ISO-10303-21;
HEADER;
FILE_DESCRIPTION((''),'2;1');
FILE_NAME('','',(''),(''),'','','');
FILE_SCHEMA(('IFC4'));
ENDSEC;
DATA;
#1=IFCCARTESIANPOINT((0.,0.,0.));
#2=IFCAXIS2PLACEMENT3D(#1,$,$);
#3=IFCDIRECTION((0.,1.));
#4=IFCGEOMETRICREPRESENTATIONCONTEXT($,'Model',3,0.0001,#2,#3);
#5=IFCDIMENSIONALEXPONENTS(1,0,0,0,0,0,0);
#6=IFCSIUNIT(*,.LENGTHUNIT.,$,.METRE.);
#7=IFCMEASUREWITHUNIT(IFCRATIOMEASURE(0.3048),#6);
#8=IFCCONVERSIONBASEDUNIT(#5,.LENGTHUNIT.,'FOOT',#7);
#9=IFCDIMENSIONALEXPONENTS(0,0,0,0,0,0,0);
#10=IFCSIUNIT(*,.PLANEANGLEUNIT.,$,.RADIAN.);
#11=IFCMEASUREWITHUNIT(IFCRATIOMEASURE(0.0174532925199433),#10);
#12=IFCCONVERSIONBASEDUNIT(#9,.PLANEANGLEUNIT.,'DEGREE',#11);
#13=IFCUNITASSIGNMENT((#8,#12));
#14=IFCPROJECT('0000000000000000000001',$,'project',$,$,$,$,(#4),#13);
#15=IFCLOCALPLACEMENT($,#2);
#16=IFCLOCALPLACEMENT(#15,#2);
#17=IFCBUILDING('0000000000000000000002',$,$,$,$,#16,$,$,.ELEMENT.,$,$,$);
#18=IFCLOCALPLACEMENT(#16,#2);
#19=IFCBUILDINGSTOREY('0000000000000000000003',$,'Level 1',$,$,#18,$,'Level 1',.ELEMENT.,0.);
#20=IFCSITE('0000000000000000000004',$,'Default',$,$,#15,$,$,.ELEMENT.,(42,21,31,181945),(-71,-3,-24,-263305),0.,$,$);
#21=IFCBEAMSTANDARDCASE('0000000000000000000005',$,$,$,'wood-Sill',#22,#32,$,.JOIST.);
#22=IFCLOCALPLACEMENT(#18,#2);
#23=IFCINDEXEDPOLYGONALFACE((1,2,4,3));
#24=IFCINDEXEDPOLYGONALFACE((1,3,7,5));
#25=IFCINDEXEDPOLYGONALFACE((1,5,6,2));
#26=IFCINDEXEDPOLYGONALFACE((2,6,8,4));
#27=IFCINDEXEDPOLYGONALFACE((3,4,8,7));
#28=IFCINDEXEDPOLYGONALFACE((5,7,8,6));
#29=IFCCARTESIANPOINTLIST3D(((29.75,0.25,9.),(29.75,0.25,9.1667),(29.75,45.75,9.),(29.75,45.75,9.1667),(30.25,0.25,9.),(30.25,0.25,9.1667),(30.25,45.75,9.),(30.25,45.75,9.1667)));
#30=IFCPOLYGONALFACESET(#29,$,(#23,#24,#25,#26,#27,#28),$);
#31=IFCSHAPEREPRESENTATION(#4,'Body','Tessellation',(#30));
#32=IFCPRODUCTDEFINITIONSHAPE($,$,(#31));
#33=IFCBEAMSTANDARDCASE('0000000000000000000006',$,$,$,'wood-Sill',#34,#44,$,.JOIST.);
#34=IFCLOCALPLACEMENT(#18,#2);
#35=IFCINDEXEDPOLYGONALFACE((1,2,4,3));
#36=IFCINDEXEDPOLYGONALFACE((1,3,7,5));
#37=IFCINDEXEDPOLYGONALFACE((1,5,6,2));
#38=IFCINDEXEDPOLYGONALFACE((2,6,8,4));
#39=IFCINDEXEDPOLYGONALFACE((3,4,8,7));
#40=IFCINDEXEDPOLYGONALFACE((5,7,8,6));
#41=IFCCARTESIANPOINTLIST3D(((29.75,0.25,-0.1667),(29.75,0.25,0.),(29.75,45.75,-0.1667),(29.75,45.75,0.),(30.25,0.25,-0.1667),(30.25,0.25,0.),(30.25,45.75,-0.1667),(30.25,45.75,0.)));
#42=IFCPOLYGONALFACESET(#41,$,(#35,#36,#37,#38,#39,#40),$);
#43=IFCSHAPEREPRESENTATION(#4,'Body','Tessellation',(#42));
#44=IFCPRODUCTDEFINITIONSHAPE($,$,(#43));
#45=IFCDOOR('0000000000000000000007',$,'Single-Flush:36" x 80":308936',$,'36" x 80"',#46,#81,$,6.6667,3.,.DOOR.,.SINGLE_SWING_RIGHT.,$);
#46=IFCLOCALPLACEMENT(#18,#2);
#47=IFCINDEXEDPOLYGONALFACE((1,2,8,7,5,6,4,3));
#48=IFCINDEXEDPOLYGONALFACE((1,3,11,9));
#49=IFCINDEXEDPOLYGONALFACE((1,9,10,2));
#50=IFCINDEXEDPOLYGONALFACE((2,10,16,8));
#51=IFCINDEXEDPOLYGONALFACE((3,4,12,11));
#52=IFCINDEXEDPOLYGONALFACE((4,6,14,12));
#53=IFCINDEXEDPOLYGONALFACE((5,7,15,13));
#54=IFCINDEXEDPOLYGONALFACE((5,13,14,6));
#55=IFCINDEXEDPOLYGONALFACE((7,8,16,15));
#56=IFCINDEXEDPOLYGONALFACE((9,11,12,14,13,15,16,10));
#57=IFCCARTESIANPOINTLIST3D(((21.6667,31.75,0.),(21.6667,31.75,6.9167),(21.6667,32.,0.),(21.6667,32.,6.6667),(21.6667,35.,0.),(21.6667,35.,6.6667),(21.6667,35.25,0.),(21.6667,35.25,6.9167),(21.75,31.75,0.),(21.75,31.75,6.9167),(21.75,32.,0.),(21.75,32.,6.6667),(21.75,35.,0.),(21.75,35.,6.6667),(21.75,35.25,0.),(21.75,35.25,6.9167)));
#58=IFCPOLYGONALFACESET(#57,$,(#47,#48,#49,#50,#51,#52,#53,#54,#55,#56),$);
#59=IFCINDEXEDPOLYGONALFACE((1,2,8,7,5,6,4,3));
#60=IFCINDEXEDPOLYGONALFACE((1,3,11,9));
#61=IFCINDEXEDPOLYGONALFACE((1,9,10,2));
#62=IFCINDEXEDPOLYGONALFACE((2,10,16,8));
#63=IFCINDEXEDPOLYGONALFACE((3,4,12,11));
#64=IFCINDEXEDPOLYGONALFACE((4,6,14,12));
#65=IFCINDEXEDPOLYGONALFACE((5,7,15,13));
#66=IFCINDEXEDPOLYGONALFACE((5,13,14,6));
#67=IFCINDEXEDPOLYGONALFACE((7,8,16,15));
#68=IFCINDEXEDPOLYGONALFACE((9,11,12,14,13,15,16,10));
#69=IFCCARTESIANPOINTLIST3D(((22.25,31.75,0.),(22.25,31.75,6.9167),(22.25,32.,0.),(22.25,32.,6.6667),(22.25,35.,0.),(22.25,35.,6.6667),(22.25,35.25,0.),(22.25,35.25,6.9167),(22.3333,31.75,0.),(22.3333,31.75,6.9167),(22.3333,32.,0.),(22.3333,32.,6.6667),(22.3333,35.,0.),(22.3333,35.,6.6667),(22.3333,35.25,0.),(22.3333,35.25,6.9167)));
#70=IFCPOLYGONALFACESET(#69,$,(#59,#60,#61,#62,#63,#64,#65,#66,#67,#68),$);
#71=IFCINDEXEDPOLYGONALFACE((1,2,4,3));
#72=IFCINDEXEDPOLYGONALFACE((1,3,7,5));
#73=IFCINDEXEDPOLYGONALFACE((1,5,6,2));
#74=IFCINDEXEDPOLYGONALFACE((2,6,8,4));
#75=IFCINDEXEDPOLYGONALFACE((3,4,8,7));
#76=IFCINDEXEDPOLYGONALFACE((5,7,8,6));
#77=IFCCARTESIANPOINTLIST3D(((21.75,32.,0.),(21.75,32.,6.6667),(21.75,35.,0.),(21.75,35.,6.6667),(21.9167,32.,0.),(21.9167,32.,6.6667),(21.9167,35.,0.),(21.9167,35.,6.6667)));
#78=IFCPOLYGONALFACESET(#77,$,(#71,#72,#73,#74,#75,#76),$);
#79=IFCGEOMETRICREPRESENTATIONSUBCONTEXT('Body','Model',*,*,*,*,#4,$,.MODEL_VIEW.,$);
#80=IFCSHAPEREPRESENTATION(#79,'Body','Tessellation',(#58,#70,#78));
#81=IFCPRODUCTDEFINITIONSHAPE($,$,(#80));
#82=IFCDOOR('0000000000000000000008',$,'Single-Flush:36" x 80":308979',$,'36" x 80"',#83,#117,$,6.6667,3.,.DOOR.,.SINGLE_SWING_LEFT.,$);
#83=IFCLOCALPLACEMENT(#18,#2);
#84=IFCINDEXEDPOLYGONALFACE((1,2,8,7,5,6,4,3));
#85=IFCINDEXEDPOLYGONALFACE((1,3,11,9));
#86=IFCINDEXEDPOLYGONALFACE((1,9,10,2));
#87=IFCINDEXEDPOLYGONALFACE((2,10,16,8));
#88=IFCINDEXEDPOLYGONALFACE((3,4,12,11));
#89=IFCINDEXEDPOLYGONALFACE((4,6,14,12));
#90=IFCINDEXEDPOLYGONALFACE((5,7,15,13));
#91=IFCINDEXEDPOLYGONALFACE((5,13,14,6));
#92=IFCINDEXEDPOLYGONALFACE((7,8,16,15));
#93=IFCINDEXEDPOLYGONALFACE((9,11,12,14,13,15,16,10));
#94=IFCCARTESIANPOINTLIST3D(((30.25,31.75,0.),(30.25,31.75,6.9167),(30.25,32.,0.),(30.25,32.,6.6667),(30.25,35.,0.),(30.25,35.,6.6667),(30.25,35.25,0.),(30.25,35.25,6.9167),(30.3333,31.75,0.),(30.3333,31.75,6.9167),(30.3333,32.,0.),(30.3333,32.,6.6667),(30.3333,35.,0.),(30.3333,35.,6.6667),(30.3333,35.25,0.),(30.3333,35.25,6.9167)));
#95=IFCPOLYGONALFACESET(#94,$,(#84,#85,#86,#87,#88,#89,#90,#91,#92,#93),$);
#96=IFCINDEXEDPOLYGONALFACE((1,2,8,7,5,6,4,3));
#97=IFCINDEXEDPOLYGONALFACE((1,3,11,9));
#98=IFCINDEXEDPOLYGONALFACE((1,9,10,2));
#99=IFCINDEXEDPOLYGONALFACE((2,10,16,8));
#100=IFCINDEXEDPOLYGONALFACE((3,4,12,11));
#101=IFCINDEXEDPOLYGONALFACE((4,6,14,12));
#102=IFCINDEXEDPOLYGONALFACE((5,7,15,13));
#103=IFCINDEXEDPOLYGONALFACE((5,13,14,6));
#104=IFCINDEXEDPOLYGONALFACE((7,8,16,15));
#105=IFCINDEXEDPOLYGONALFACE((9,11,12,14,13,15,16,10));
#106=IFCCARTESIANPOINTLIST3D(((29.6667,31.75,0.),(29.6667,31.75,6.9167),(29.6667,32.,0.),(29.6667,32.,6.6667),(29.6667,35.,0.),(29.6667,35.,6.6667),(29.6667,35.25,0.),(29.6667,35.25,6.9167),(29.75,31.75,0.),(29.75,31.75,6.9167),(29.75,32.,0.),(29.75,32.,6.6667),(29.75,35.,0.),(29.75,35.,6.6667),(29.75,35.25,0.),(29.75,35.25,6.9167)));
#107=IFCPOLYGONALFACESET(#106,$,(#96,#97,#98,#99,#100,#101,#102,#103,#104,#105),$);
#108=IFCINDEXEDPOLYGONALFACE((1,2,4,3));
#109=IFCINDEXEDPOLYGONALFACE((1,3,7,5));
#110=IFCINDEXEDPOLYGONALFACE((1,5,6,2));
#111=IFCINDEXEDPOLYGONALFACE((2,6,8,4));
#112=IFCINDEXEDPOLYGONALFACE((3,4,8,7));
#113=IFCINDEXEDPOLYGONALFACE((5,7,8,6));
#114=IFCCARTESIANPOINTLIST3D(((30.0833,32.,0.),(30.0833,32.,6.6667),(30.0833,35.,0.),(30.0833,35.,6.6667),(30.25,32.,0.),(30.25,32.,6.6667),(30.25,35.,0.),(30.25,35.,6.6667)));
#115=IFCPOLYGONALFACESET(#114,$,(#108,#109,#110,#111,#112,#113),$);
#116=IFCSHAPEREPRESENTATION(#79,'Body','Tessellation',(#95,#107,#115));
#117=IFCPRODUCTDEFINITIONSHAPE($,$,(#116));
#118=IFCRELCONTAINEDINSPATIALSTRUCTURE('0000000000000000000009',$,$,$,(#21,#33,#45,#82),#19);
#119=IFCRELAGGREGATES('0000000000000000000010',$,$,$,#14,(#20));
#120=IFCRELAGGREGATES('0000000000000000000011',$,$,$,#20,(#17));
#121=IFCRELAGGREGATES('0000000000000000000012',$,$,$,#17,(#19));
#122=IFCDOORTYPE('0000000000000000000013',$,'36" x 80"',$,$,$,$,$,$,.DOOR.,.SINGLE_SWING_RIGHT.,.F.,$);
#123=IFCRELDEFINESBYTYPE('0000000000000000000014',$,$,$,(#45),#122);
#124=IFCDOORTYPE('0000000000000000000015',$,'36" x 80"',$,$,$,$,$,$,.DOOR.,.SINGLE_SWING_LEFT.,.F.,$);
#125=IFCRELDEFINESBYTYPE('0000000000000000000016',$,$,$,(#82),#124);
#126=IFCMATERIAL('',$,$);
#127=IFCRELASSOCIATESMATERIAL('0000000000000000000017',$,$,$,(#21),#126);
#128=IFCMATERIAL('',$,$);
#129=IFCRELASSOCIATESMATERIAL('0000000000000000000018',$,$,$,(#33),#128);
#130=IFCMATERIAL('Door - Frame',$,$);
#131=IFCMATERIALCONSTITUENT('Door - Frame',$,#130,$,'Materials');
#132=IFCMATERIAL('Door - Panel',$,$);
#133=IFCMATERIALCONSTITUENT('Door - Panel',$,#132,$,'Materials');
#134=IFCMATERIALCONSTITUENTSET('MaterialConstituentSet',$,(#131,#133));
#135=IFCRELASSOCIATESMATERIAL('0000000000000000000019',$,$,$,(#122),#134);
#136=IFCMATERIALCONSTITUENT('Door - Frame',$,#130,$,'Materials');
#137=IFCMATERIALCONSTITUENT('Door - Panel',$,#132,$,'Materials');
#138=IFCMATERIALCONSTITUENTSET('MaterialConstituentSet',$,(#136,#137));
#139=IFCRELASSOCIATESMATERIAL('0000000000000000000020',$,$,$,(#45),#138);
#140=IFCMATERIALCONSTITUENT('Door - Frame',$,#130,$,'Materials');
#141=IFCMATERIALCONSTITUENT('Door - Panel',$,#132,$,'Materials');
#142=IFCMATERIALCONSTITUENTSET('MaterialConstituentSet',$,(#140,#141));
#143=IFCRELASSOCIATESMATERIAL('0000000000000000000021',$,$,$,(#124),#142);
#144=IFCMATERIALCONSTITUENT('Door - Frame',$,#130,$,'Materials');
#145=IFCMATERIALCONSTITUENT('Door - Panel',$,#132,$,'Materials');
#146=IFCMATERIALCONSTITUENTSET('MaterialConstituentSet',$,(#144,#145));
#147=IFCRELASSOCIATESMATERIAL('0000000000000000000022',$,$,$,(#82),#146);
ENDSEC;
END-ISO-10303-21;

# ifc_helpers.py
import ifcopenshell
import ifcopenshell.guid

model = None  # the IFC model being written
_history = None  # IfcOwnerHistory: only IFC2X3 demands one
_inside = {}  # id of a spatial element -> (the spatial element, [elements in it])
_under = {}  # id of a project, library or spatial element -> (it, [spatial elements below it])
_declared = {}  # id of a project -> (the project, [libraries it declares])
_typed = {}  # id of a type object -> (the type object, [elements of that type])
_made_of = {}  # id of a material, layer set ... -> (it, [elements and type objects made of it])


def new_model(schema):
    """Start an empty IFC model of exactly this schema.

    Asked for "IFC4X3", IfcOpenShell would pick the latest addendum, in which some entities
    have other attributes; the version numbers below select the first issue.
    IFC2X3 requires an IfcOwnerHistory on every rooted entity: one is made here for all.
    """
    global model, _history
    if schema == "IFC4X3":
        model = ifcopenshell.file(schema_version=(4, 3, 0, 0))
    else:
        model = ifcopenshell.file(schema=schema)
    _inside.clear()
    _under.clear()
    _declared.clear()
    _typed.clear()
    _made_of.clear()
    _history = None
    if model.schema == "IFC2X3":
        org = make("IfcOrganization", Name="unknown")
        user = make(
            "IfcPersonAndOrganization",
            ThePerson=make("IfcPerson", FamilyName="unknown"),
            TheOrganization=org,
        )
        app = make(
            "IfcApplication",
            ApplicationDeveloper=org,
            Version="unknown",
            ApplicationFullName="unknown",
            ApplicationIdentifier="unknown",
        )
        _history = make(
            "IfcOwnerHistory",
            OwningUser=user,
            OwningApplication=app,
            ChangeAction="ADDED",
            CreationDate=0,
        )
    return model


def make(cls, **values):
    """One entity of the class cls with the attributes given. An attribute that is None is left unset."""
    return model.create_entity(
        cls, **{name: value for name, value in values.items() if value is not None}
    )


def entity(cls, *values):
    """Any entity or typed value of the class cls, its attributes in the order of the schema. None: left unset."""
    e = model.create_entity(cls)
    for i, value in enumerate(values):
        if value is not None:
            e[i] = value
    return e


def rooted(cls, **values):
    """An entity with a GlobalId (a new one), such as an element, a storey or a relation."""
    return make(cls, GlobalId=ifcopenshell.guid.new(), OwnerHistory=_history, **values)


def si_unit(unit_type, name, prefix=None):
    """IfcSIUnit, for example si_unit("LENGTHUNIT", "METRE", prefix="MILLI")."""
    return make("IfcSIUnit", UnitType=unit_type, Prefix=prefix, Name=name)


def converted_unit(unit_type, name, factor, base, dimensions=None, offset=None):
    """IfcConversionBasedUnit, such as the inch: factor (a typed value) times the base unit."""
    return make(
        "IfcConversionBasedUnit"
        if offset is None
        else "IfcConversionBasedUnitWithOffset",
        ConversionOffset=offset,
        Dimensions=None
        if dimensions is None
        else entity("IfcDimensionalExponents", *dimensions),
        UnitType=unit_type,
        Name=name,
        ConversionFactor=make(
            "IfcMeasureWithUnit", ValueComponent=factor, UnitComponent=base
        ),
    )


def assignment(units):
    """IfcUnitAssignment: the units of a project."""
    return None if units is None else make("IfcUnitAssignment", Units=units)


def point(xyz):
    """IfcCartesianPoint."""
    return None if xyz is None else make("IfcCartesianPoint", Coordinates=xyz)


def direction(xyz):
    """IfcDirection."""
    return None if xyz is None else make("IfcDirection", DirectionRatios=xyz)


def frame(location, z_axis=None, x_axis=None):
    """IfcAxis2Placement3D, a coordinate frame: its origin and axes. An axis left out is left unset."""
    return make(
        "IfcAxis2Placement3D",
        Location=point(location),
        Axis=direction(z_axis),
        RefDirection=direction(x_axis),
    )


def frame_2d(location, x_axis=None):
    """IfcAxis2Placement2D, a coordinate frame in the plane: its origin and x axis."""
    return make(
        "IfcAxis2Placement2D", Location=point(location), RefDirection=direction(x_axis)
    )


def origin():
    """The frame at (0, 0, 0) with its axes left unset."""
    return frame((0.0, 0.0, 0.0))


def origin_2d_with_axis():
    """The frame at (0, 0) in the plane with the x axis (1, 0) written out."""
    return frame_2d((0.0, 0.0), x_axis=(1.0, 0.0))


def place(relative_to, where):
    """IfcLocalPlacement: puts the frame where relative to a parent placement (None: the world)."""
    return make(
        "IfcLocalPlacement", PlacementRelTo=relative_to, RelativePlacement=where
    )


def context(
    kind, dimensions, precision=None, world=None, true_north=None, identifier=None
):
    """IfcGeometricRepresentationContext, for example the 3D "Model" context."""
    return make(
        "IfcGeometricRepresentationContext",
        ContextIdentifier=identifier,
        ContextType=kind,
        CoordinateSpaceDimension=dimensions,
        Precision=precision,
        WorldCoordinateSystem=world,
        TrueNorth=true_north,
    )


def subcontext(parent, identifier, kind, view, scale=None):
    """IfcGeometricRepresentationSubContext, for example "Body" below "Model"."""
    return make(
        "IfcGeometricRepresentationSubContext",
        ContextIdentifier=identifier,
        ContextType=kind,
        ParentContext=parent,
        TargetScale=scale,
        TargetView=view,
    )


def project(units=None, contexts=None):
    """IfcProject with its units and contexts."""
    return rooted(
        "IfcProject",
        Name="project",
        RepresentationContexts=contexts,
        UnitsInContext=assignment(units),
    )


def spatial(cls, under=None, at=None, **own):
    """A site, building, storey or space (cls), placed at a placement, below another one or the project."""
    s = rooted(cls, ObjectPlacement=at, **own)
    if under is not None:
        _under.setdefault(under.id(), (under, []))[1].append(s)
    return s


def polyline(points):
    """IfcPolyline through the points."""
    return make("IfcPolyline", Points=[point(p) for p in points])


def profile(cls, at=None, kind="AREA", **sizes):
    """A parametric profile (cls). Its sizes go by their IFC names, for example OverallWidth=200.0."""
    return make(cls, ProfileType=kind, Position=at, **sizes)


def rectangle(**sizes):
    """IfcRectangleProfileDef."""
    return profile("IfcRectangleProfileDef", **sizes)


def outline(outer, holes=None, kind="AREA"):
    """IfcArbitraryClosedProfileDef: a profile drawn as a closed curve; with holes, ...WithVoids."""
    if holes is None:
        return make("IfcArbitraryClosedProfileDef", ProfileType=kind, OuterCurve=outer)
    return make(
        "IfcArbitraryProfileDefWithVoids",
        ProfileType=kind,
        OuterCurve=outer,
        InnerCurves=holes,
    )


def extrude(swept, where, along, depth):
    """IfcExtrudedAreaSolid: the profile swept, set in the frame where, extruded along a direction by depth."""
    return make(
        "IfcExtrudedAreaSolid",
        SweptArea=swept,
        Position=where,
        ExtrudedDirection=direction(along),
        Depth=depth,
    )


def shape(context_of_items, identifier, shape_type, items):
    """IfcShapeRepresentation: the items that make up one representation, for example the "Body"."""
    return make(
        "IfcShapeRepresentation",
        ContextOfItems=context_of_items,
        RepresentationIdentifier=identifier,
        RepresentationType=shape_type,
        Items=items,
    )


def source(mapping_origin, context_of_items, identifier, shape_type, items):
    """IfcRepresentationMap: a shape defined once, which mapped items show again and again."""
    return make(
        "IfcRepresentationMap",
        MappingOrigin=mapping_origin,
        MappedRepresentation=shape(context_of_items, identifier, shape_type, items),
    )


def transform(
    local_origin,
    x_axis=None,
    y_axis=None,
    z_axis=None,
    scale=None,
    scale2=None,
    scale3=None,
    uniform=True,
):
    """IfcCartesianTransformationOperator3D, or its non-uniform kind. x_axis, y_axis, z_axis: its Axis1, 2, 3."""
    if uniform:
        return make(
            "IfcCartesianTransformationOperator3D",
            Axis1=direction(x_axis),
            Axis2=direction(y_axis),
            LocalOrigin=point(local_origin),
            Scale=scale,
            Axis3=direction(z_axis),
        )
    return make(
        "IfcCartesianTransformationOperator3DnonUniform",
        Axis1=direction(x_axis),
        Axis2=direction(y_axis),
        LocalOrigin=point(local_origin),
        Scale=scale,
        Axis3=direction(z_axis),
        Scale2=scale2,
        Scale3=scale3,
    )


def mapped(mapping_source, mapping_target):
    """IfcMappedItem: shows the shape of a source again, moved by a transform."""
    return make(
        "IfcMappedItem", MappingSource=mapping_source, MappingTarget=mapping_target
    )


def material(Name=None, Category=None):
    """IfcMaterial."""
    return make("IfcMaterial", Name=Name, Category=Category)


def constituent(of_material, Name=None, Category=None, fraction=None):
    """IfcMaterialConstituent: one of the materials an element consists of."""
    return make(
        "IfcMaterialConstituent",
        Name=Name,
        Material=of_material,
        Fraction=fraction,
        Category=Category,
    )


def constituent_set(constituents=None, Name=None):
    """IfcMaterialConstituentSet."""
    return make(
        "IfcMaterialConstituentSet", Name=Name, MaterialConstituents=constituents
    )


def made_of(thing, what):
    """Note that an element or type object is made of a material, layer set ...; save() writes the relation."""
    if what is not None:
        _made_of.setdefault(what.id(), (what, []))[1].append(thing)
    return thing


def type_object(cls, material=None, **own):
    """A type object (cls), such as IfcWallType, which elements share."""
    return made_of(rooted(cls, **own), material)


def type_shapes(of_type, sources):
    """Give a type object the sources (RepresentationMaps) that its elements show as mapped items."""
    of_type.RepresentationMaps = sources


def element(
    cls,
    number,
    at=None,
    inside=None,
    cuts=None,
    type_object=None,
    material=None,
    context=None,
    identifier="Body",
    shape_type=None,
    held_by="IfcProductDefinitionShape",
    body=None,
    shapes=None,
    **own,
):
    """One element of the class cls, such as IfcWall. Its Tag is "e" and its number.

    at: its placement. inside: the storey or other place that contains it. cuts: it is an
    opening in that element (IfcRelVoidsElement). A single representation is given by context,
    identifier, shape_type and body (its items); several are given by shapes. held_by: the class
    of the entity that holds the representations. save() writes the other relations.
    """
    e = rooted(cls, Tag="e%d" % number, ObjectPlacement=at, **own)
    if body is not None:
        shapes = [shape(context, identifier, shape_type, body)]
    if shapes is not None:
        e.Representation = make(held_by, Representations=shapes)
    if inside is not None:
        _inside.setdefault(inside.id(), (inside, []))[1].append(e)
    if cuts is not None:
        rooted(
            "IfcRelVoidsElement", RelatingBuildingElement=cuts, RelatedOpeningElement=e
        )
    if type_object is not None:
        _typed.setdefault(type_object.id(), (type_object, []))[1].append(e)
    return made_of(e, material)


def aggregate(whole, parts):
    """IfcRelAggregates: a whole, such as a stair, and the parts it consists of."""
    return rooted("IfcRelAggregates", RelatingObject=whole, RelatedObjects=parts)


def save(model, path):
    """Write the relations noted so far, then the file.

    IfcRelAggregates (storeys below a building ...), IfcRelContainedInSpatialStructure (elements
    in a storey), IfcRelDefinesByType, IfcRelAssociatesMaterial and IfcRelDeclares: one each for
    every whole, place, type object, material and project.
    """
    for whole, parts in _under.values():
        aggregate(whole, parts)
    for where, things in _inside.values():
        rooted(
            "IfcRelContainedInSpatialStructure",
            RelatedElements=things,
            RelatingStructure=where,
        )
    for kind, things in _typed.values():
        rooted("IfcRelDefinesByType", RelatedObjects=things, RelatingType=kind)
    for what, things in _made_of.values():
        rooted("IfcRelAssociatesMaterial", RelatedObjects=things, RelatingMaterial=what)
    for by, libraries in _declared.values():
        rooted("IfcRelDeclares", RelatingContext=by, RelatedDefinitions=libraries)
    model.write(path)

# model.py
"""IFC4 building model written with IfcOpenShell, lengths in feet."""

from ifc_helpers import new_model, entity, si_unit, converted_unit, direction, frame, origin, origin_2d_with_axis, place, context, subcontext, project, spatial, polyline, rectangle, outline, extrude, source, transform, mapped, material, constituent, constituent_set, type_object, type_shapes, element, save


model = new_model("IFC4")

# Units and contexts
model_context = context("Model", 3, precision=0.0001, world=origin(), true_north=direction((0.0, 1.0)))
body_context = subcontext(model_context, "Body", "Model", "MODEL_VIEW")
ifc_project = project(units=[converted_unit("LENGTHUNIT", "FOOT", entity("IfcRatioMeasure", 0.3048), si_unit("LENGTHUNIT", "METRE"), dimensions=[1, 0, 0, 0, 0, 0, 0]), converted_unit("PLANEANGLEUNIT", "DEGREE", entity("IfcRatioMeasure", 0.0174532925199433), si_unit("PLANEANGLEUNIT", "RADIAN"), dimensions=[0, 0, 0, 0, 0, 0, 0])], contexts=[model_context])

# Site, building, storey
site_placement = place(None, origin())
site = spatial("IfcSite", under=ifc_project, at=site_placement, Name="Default", CompositionType="ELEMENT", RefLatitude=(42, 21, 31, 181945), RefLongitude=(-71, -3, -24, -263305), RefElevation=0.0)
building_placement = place(site_placement, origin())
building = spatial("IfcBuilding", under=site, at=building_placement, CompositionType="ELEMENT")
storey_placement = place(building_placement, origin())
storey = spatial("IfcBuildingStorey", under=building, at=storey_placement, Name="Level 1", LongName="Level 1", CompositionType="ELEMENT", Elevation=0.0)

# Shared definitions
placement_1 = place(storey_placement, frame((30.0, 45.75, 0.0), z_axis=(0.0, 0.0, 1.0), x_axis=(0.0, -1.0, 0.0)))

# Beams
ifc_material_1 = material(Name="")
beam_1_placement = place(placement_1, frame((22.75, 0.0, 9.0), z_axis=(0.0, 0.0, 1.0), x_axis=(1.0, 0.0, 0.0)))
element("IfcBeamStandardCase", 1, at=beam_1_placement, inside=storey, material=ifc_material_1, ObjectType="wood-Sill", PredefinedType="JOIST", context=model_context, shape_type="SweptSolid", body=[
    extrude(rectangle(XDim=45.5, YDim=0.5), origin(), (0.0, 0.0, 1.0), 0.1667),
])
ifc_material_2 = material(Name="")
beam_2_placement = place(placement_1, frame((22.75, 0.0, -0.1667), z_axis=(0.0, 0.0, 1.0), x_axis=(1.0, 0.0, 0.0)))
element("IfcBeamStandardCase", 2, at=beam_2_placement, inside=storey, material=ifc_material_2, ObjectType="wood-Sill", PredefinedType="JOIST", context=model_context, shape_type="SweptSolid", body=[
    extrude(rectangle(XDim=45.5, YDim=0.5), origin(), (0.0, 0.0, 1.0), 0.1667),
])

# Doors
ifc_material_3 = material(Name="Door - Frame")
ifc_constituent_1 = constituent(ifc_material_3, Name="Door - Frame", Category="Materials")
ifc_material_4 = material(Name="Door - Panel")
ifc_constituent_2 = constituent(ifc_material_4, Name="Door - Panel", Category="Materials")
ifc_constituent_set_1 = constituent_set(constituents=[ifc_constituent_1, ifc_constituent_2], Name="MaterialConstituentSet")
ifc_constituent_3 = constituent(ifc_material_3, Name="Door - Frame", Category="Materials")
ifc_constituent_4 = constituent(ifc_material_4, Name="Door - Panel", Category="Materials")
ifc_constituent_set_2 = constituent_set(constituents=[ifc_constituent_3, ifc_constituent_4], Name="MaterialConstituentSet")
door_type_1 = type_object("IfcDoorType", Name="36\" x 80\"", OperationType="SINGLE_SWING_RIGHT", ParameterTakesPrecedence=False, PredefinedType="DOOR", material=ifc_constituent_set_2)
shared_shape_1 = source(origin(), body_context, "Body", "SweptSolid", [
    extrude(outline(polyline([(-1.75, -3.5208), (1.75, -3.5208), (1.75, 3.3958), (1.5, 3.3958), (1.5, -3.2708), (-1.5, -3.2708), (-1.5, 3.3958), (-1.75, 3.3958), (-1.75, -3.5208)])), frame((1.5, 0.5, 3.3958), z_axis=(0.0, 1.0, 0.0), x_axis=(1.0, 0.0, 0.0)), (0.0, 0.0, 1.0), 0.0833),
    extrude(outline(polyline([(-3.5208, -1.75), (3.3958, -1.75), (3.3958, -1.5), (-3.2708, -1.5), (-3.2708, 1.5), (3.3958, 1.5), (3.3958, 1.75), (-3.5208, 1.75), (-3.5208, -1.75)])), frame((1.5, -0.0833, 3.3958), z_axis=(0.0, 1.0, 0.0), x_axis=(0.0, 0.0, -1.0)), (0.0, 0.0, 1.0), 0.0833),
    extrude(rectangle(XDim=0.1667, YDim=3.0, at=origin_2d_with_axis()), frame((1.5, 0.4167, 0.0), z_axis=(0.0, 0.0, 1.0), x_axis=(0.0, 1.0, 0.0)), (0.0, 0.0, 1.0), 6.6667),
])
type_shapes(door_type_1, [shared_shape_1])
placement_2 = place(storey_placement, frame((22.0, 45.75, 0.0), z_axis=(0.0, 0.0, 1.0), x_axis=(0.0, -1.0, 0.0)))
placement_3 = place(placement_2, frame((13.75, 0.25, 0.0)))
door_1_placement = place(placement_3, frame((0.0, 0.0, 0.0), z_axis=(0.0, 0.0, 1.0), x_axis=(-1.0, 0.0, 0.0)))
element("IfcDoor", 3, at=door_1_placement, inside=storey, type_object=door_type_1, material=ifc_constituent_set_1, Name="Single-Flush:36\" x 80\":308936", ObjectType="36\" x 80\"", OperationType="SINGLE_SWING_RIGHT", OverallHeight=6.6667, OverallWidth=3.0, PredefinedType="DOOR", context=body_context, shape_type="MappedRepresentation", body=[
    mapped(shared_shape_1, transform((0.0, 0.0, 0.0), scale=1.0)),
])
ifc_constituent_5 = constituent(ifc_material_3, Name="Door - Frame", Category="Materials")
ifc_constituent_6 = constituent(ifc_material_4, Name="Door - Panel", Category="Materials")
ifc_constituent_set_3 = constituent_set(constituents=[ifc_constituent_5, ifc_constituent_6], Name="MaterialConstituentSet")
ifc_constituent_7 = constituent(ifc_material_3, Name="Door - Frame", Category="Materials")
ifc_constituent_8 = constituent(ifc_material_4, Name="Door - Panel", Category="Materials")
ifc_constituent_set_4 = constituent_set(constituents=[ifc_constituent_7, ifc_constituent_8], Name="MaterialConstituentSet")
door_type_2 = type_object("IfcDoorType", Name="36\" x 80\"", OperationType="SINGLE_SWING_LEFT", ParameterTakesPrecedence=False, PredefinedType="DOOR", material=ifc_constituent_set_4)
shared_shape_2 = source(origin(), body_context, "Body", "SweptSolid", [
    extrude(outline(polyline([(-1.75, -3.5208), (1.75, -3.5208), (1.75, 3.3958), (1.5, 3.3958), (1.5, -3.2708), (-1.5, -3.2708), (-1.5, 3.3958), (-1.75, 3.3958), (-1.75, -3.5208)])), frame((1.5, 0.5833, 3.3958), z_axis=(0.0, -1.0, 0.0), x_axis=(-1.0, 0.0, 0.0)), (0.0, 0.0, 1.0), 0.0833),
    extrude(outline(polyline([(-3.5208, -1.75), (3.3958, -1.75), (3.3958, -1.5), (-3.2708, -1.5), (-3.2708, 1.5), (3.3958, 1.5), (3.3958, 1.75), (-3.5208, 1.75), (-3.5208, -1.75)])), frame((1.5, 0.0, 3.3958), z_axis=(0.0, -1.0, 0.0), x_axis=(0.0, 0.0, -1.0)), (0.0, 0.0, 1.0), 0.0833),
    extrude(rectangle(XDim=3.0, YDim=0.1667, at=origin_2d_with_axis()), frame((1.5, 0.4167, 0.0)), (0.0, 0.0, 1.0), 6.6667),
])
type_shapes(door_type_2, [shared_shape_2])
placement_4 = place(placement_1, frame((10.75, -0.25, 0.0)))
door_2_placement = place(placement_4, origin())
element("IfcDoor", 4, at=door_2_placement, inside=storey, type_object=door_type_2, material=ifc_constituent_set_3, Name="Single-Flush:36\" x 80\":308979", ObjectType="36\" x 80\"", OperationType="SINGLE_SWING_LEFT", OverallHeight=6.6667, OverallWidth=3.0, PredefinedType="DOOR", context=body_context, shape_type="MappedRepresentation", body=[
    mapped(shared_shape_2, transform((0.0, 0.0, 0.0), scale=1.0)),
])

save(model, "model.ifc")
